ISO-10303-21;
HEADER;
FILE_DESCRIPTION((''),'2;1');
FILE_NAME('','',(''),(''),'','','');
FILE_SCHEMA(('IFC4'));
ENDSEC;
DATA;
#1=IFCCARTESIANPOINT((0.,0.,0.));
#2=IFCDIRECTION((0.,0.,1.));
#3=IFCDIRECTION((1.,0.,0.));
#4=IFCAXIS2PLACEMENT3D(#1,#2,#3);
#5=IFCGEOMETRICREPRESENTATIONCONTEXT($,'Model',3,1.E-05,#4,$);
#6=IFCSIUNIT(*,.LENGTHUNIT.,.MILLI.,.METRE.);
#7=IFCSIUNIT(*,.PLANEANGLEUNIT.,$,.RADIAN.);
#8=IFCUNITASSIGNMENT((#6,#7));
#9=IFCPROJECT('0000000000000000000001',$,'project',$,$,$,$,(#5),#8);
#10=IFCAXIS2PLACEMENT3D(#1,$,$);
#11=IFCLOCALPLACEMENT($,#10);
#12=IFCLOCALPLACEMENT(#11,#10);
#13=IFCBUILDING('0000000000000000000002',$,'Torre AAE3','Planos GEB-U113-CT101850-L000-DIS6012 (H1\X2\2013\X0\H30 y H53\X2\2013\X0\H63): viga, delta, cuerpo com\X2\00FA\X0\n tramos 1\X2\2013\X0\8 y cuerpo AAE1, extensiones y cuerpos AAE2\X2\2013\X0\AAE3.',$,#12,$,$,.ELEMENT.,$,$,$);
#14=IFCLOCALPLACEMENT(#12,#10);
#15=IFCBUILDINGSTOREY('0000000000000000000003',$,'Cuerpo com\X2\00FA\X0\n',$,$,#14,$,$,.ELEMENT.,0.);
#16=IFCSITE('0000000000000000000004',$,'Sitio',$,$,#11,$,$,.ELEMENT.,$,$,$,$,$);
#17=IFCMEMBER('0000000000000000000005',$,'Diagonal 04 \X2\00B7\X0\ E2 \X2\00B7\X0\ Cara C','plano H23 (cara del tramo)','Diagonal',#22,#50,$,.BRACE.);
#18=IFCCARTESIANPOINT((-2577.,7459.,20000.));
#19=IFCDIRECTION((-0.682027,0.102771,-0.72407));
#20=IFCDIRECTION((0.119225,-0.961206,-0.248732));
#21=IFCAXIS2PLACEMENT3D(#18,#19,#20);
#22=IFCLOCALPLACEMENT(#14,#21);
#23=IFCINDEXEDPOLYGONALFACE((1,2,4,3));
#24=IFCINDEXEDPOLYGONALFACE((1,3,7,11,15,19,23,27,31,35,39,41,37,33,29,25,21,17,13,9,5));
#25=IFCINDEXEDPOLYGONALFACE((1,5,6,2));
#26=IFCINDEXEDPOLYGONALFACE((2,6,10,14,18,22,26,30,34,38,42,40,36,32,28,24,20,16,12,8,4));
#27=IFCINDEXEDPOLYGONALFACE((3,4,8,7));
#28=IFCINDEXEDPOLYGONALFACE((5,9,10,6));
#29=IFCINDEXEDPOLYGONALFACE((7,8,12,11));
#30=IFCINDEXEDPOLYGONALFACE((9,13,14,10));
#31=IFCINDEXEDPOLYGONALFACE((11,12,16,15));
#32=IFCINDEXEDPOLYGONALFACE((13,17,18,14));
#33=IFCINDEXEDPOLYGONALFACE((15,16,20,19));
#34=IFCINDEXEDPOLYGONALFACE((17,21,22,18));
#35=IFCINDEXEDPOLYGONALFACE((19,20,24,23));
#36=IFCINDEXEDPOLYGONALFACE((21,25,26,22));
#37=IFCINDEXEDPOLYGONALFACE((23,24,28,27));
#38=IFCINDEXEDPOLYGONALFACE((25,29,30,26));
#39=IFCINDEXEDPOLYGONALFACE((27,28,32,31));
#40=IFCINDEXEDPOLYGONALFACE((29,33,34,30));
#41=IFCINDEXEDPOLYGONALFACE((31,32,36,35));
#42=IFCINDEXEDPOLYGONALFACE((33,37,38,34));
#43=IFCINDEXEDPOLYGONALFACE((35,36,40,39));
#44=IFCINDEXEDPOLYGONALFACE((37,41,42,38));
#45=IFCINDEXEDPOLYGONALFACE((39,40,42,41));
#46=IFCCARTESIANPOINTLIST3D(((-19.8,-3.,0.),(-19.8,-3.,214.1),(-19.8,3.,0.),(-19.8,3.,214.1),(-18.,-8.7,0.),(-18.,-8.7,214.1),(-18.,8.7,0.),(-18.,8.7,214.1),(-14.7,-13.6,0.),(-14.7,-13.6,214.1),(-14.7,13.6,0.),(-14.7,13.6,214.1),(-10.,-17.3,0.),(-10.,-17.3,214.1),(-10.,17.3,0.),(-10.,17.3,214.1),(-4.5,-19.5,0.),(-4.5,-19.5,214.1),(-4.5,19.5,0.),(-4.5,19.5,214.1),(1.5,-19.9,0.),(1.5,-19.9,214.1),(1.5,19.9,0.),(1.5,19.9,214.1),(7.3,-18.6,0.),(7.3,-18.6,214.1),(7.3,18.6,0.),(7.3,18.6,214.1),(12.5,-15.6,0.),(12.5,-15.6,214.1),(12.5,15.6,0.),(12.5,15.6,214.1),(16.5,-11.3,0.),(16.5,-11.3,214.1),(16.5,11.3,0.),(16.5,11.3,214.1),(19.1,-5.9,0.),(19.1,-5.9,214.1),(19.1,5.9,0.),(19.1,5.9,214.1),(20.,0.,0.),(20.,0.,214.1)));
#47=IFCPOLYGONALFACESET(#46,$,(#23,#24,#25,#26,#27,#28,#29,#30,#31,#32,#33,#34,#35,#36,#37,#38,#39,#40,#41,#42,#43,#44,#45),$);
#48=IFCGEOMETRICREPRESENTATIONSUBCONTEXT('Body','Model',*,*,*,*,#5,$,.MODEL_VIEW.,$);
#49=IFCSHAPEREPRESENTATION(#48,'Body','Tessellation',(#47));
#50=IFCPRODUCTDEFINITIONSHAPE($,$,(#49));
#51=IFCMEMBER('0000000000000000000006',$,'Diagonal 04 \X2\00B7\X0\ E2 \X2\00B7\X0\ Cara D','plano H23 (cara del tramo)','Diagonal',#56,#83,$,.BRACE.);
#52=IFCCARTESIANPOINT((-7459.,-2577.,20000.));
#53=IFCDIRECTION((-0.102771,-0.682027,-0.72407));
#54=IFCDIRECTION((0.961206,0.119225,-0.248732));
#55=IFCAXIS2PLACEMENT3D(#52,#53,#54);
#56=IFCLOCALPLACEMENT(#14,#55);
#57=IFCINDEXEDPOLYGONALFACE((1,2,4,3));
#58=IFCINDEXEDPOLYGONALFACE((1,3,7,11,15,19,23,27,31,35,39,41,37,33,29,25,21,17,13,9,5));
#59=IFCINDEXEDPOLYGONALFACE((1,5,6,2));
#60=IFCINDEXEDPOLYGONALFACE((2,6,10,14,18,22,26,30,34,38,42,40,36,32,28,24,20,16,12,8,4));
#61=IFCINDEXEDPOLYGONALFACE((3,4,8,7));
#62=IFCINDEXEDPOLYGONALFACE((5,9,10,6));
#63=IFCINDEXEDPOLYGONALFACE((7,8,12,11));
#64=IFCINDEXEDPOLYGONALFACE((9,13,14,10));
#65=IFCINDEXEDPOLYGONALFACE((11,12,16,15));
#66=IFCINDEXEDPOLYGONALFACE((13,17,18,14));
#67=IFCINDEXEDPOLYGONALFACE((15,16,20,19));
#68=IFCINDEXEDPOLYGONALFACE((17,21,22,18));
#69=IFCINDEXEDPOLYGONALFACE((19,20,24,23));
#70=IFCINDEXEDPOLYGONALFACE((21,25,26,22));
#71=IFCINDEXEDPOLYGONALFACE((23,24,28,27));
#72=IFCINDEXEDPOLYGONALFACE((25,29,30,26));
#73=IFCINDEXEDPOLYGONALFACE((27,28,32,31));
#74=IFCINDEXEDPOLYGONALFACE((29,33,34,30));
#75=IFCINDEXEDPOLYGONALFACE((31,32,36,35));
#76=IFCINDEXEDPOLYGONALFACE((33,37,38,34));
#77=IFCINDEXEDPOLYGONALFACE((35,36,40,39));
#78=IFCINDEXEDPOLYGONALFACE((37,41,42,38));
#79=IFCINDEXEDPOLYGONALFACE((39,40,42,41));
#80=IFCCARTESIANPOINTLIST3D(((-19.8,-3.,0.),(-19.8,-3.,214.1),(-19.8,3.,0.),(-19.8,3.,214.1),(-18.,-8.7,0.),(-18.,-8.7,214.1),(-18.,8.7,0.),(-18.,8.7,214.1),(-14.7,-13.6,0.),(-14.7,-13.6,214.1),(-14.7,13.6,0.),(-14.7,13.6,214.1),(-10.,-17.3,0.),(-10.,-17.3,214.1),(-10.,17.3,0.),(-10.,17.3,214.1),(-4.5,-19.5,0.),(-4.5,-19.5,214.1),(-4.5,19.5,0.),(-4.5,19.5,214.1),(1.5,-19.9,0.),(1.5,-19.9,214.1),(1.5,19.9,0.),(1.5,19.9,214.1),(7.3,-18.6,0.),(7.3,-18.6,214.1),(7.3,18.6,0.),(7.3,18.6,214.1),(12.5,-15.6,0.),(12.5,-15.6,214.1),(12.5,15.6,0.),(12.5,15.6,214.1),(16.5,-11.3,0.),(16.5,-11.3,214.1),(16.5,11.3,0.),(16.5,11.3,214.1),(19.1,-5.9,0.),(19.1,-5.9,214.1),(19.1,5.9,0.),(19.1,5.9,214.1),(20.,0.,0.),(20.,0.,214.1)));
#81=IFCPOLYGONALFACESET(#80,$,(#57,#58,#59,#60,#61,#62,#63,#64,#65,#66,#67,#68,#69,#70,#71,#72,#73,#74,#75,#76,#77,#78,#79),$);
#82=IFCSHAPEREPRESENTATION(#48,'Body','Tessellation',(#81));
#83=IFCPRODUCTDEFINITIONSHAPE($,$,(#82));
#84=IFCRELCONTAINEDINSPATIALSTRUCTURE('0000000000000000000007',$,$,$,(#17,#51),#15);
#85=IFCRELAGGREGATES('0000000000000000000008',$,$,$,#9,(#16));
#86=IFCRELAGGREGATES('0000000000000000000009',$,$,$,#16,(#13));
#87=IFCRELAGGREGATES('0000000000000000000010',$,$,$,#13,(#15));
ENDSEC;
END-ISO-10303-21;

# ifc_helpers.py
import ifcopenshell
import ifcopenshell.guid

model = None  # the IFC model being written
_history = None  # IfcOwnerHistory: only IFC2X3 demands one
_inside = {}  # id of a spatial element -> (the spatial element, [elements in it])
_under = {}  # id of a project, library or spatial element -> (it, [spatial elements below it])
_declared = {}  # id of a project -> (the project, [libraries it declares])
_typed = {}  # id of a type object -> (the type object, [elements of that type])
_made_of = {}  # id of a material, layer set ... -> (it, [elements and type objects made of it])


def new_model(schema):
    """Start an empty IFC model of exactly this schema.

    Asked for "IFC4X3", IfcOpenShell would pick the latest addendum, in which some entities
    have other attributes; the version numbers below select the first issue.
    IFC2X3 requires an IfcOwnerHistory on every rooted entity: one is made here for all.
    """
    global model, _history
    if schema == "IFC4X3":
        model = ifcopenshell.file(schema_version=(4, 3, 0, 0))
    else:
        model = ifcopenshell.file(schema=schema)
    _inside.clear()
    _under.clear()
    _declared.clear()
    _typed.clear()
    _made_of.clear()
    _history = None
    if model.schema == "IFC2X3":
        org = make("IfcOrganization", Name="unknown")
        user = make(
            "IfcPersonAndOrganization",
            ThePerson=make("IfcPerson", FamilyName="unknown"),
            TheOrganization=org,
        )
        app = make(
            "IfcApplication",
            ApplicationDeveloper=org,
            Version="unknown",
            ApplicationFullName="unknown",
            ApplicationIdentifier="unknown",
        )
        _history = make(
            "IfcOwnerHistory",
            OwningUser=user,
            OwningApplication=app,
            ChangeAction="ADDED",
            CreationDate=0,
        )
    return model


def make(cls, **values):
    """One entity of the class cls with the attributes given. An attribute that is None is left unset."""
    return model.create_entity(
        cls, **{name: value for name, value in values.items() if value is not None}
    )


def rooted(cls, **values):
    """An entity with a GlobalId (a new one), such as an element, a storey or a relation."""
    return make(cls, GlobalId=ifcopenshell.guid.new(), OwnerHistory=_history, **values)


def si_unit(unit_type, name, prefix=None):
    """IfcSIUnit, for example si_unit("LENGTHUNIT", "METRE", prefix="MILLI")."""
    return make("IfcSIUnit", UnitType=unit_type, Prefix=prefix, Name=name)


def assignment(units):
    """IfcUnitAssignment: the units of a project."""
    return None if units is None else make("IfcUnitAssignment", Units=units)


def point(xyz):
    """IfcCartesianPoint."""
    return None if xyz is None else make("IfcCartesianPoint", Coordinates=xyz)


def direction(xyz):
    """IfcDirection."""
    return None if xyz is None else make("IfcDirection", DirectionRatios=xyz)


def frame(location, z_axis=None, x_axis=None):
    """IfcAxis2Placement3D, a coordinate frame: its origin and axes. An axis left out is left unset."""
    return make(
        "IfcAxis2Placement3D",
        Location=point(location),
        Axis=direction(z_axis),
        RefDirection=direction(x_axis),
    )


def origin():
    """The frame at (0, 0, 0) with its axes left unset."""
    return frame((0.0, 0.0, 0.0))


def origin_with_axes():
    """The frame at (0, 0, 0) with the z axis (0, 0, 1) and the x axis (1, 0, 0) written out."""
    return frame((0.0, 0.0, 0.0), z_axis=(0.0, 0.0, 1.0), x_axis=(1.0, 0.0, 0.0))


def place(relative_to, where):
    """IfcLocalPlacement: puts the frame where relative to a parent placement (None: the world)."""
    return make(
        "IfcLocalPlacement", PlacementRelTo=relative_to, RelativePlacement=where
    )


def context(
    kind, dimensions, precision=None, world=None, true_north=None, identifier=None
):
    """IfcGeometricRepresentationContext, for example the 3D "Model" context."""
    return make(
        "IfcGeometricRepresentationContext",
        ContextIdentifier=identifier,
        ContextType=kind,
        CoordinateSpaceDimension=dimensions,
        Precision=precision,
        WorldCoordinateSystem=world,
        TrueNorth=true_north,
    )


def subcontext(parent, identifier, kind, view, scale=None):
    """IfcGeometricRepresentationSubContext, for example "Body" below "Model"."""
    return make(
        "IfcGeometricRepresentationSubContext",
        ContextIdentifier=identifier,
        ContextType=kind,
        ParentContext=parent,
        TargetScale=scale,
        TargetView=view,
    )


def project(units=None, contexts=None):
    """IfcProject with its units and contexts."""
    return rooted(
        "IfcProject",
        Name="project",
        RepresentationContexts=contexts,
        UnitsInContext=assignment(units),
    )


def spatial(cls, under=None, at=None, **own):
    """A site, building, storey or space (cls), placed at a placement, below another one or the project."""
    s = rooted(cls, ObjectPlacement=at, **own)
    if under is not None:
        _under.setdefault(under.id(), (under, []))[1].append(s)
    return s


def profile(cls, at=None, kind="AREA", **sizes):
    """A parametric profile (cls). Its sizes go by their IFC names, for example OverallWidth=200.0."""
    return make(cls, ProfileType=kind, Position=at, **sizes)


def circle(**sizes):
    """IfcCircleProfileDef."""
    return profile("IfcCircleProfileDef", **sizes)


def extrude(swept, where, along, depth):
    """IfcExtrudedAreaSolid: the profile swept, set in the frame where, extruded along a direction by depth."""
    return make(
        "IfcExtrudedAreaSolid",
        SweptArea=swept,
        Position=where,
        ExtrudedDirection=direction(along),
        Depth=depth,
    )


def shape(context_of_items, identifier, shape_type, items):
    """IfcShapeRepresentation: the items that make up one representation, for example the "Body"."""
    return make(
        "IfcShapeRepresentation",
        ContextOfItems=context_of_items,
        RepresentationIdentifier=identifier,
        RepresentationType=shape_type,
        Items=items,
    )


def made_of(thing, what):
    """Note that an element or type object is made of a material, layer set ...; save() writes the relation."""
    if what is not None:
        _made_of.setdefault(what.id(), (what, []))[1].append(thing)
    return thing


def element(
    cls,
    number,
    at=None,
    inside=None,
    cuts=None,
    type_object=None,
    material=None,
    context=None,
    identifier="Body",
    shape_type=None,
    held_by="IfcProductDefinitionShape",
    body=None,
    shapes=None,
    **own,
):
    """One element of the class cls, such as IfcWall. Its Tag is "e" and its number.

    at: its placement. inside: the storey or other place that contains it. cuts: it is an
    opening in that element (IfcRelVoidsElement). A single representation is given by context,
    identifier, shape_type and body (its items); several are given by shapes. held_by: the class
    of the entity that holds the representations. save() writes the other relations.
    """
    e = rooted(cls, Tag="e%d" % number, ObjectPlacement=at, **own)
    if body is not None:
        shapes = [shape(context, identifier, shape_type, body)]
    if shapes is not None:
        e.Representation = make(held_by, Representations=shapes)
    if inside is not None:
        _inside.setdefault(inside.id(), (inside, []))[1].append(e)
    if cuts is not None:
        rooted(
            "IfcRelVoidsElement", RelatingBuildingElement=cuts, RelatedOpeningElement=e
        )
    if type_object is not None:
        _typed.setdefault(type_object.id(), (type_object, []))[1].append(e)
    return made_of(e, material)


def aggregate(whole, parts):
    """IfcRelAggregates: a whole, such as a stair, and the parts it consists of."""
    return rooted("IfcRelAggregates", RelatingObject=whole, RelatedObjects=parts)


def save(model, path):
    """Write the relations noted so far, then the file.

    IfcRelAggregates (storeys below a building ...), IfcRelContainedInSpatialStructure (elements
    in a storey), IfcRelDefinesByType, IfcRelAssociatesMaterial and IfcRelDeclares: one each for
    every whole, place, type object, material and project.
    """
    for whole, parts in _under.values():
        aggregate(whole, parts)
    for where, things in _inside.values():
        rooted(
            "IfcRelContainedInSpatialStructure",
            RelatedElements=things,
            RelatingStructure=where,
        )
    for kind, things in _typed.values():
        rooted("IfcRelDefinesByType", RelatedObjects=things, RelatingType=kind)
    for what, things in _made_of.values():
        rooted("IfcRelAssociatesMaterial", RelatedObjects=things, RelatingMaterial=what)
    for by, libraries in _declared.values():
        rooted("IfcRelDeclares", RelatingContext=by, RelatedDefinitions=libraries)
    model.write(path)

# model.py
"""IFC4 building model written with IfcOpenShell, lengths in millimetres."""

from ifc_helpers import new_model, si_unit, frame, origin, origin_with_axes, place, context, subcontext, project, spatial, circle, extrude, element, save


model = new_model("IFC4")

# Units and contexts
model_context = context("Model", 3, precision=1e-05, world=origin_with_axes())
body_context = subcontext(model_context, "Body", "Model", "MODEL_VIEW")
ifc_project = project(units=[si_unit("LENGTHUNIT", "METRE", prefix="MILLI"), si_unit("PLANEANGLEUNIT", "RADIAN")], contexts=[model_context])

# Site, building, storey
site_placement = place(None, origin())
site = spatial("IfcSite", under=ifc_project, at=site_placement, Name="Sitio", CompositionType="ELEMENT")
building_placement = place(site_placement, origin())
building = spatial("IfcBuilding", under=site, at=building_placement, Name="Torre AAE3", Description="Planos GEB-U113-CT101850-L000-DIS6012 (H1–H30 y H53–H63): viga, delta, cuerpo común tramos 1–8 y cuerpo AAE1, extensiones y cuerpos AAE2–AAE3.", CompositionType="ELEMENT")
storey_placement = place(building_placement, origin())
storey = spatial("IfcBuildingStorey", under=building, at=storey_placement, Name="Cuerpo común", CompositionType="ELEMENT", Elevation=0.0)

# Members
for number, where, z_axis, x_axis, name in (
    (1, (-2577.0, 7459.0, 20000.0), (-0.682027, 0.102771, -0.72407), (0.119225, -0.961206, -0.248732), "Diagonal 04 · E2 · Cara C"),
    (2, (-7459.0, -2577.0, 20000.0), (-0.102771, -0.682027, -0.72407), (0.961206, 0.119225, -0.248732), "Diagonal 04 · E2 · Cara D"),
):
    element("IfcMember", number, at=place(storey_placement, frame(where, z_axis=z_axis, x_axis=x_axis)), inside=storey, Name=name, Description="plano H23 (cara del tramo)", ObjectType="Diagonal", PredefinedType="BRACE", context=body_context, shape_type="SweptSolid", body=[
        extrude(circle(Radius=20.0), None, (0.0, 0.0, 1.0), 214.1),
    ])

save(model, "model.ifc")
